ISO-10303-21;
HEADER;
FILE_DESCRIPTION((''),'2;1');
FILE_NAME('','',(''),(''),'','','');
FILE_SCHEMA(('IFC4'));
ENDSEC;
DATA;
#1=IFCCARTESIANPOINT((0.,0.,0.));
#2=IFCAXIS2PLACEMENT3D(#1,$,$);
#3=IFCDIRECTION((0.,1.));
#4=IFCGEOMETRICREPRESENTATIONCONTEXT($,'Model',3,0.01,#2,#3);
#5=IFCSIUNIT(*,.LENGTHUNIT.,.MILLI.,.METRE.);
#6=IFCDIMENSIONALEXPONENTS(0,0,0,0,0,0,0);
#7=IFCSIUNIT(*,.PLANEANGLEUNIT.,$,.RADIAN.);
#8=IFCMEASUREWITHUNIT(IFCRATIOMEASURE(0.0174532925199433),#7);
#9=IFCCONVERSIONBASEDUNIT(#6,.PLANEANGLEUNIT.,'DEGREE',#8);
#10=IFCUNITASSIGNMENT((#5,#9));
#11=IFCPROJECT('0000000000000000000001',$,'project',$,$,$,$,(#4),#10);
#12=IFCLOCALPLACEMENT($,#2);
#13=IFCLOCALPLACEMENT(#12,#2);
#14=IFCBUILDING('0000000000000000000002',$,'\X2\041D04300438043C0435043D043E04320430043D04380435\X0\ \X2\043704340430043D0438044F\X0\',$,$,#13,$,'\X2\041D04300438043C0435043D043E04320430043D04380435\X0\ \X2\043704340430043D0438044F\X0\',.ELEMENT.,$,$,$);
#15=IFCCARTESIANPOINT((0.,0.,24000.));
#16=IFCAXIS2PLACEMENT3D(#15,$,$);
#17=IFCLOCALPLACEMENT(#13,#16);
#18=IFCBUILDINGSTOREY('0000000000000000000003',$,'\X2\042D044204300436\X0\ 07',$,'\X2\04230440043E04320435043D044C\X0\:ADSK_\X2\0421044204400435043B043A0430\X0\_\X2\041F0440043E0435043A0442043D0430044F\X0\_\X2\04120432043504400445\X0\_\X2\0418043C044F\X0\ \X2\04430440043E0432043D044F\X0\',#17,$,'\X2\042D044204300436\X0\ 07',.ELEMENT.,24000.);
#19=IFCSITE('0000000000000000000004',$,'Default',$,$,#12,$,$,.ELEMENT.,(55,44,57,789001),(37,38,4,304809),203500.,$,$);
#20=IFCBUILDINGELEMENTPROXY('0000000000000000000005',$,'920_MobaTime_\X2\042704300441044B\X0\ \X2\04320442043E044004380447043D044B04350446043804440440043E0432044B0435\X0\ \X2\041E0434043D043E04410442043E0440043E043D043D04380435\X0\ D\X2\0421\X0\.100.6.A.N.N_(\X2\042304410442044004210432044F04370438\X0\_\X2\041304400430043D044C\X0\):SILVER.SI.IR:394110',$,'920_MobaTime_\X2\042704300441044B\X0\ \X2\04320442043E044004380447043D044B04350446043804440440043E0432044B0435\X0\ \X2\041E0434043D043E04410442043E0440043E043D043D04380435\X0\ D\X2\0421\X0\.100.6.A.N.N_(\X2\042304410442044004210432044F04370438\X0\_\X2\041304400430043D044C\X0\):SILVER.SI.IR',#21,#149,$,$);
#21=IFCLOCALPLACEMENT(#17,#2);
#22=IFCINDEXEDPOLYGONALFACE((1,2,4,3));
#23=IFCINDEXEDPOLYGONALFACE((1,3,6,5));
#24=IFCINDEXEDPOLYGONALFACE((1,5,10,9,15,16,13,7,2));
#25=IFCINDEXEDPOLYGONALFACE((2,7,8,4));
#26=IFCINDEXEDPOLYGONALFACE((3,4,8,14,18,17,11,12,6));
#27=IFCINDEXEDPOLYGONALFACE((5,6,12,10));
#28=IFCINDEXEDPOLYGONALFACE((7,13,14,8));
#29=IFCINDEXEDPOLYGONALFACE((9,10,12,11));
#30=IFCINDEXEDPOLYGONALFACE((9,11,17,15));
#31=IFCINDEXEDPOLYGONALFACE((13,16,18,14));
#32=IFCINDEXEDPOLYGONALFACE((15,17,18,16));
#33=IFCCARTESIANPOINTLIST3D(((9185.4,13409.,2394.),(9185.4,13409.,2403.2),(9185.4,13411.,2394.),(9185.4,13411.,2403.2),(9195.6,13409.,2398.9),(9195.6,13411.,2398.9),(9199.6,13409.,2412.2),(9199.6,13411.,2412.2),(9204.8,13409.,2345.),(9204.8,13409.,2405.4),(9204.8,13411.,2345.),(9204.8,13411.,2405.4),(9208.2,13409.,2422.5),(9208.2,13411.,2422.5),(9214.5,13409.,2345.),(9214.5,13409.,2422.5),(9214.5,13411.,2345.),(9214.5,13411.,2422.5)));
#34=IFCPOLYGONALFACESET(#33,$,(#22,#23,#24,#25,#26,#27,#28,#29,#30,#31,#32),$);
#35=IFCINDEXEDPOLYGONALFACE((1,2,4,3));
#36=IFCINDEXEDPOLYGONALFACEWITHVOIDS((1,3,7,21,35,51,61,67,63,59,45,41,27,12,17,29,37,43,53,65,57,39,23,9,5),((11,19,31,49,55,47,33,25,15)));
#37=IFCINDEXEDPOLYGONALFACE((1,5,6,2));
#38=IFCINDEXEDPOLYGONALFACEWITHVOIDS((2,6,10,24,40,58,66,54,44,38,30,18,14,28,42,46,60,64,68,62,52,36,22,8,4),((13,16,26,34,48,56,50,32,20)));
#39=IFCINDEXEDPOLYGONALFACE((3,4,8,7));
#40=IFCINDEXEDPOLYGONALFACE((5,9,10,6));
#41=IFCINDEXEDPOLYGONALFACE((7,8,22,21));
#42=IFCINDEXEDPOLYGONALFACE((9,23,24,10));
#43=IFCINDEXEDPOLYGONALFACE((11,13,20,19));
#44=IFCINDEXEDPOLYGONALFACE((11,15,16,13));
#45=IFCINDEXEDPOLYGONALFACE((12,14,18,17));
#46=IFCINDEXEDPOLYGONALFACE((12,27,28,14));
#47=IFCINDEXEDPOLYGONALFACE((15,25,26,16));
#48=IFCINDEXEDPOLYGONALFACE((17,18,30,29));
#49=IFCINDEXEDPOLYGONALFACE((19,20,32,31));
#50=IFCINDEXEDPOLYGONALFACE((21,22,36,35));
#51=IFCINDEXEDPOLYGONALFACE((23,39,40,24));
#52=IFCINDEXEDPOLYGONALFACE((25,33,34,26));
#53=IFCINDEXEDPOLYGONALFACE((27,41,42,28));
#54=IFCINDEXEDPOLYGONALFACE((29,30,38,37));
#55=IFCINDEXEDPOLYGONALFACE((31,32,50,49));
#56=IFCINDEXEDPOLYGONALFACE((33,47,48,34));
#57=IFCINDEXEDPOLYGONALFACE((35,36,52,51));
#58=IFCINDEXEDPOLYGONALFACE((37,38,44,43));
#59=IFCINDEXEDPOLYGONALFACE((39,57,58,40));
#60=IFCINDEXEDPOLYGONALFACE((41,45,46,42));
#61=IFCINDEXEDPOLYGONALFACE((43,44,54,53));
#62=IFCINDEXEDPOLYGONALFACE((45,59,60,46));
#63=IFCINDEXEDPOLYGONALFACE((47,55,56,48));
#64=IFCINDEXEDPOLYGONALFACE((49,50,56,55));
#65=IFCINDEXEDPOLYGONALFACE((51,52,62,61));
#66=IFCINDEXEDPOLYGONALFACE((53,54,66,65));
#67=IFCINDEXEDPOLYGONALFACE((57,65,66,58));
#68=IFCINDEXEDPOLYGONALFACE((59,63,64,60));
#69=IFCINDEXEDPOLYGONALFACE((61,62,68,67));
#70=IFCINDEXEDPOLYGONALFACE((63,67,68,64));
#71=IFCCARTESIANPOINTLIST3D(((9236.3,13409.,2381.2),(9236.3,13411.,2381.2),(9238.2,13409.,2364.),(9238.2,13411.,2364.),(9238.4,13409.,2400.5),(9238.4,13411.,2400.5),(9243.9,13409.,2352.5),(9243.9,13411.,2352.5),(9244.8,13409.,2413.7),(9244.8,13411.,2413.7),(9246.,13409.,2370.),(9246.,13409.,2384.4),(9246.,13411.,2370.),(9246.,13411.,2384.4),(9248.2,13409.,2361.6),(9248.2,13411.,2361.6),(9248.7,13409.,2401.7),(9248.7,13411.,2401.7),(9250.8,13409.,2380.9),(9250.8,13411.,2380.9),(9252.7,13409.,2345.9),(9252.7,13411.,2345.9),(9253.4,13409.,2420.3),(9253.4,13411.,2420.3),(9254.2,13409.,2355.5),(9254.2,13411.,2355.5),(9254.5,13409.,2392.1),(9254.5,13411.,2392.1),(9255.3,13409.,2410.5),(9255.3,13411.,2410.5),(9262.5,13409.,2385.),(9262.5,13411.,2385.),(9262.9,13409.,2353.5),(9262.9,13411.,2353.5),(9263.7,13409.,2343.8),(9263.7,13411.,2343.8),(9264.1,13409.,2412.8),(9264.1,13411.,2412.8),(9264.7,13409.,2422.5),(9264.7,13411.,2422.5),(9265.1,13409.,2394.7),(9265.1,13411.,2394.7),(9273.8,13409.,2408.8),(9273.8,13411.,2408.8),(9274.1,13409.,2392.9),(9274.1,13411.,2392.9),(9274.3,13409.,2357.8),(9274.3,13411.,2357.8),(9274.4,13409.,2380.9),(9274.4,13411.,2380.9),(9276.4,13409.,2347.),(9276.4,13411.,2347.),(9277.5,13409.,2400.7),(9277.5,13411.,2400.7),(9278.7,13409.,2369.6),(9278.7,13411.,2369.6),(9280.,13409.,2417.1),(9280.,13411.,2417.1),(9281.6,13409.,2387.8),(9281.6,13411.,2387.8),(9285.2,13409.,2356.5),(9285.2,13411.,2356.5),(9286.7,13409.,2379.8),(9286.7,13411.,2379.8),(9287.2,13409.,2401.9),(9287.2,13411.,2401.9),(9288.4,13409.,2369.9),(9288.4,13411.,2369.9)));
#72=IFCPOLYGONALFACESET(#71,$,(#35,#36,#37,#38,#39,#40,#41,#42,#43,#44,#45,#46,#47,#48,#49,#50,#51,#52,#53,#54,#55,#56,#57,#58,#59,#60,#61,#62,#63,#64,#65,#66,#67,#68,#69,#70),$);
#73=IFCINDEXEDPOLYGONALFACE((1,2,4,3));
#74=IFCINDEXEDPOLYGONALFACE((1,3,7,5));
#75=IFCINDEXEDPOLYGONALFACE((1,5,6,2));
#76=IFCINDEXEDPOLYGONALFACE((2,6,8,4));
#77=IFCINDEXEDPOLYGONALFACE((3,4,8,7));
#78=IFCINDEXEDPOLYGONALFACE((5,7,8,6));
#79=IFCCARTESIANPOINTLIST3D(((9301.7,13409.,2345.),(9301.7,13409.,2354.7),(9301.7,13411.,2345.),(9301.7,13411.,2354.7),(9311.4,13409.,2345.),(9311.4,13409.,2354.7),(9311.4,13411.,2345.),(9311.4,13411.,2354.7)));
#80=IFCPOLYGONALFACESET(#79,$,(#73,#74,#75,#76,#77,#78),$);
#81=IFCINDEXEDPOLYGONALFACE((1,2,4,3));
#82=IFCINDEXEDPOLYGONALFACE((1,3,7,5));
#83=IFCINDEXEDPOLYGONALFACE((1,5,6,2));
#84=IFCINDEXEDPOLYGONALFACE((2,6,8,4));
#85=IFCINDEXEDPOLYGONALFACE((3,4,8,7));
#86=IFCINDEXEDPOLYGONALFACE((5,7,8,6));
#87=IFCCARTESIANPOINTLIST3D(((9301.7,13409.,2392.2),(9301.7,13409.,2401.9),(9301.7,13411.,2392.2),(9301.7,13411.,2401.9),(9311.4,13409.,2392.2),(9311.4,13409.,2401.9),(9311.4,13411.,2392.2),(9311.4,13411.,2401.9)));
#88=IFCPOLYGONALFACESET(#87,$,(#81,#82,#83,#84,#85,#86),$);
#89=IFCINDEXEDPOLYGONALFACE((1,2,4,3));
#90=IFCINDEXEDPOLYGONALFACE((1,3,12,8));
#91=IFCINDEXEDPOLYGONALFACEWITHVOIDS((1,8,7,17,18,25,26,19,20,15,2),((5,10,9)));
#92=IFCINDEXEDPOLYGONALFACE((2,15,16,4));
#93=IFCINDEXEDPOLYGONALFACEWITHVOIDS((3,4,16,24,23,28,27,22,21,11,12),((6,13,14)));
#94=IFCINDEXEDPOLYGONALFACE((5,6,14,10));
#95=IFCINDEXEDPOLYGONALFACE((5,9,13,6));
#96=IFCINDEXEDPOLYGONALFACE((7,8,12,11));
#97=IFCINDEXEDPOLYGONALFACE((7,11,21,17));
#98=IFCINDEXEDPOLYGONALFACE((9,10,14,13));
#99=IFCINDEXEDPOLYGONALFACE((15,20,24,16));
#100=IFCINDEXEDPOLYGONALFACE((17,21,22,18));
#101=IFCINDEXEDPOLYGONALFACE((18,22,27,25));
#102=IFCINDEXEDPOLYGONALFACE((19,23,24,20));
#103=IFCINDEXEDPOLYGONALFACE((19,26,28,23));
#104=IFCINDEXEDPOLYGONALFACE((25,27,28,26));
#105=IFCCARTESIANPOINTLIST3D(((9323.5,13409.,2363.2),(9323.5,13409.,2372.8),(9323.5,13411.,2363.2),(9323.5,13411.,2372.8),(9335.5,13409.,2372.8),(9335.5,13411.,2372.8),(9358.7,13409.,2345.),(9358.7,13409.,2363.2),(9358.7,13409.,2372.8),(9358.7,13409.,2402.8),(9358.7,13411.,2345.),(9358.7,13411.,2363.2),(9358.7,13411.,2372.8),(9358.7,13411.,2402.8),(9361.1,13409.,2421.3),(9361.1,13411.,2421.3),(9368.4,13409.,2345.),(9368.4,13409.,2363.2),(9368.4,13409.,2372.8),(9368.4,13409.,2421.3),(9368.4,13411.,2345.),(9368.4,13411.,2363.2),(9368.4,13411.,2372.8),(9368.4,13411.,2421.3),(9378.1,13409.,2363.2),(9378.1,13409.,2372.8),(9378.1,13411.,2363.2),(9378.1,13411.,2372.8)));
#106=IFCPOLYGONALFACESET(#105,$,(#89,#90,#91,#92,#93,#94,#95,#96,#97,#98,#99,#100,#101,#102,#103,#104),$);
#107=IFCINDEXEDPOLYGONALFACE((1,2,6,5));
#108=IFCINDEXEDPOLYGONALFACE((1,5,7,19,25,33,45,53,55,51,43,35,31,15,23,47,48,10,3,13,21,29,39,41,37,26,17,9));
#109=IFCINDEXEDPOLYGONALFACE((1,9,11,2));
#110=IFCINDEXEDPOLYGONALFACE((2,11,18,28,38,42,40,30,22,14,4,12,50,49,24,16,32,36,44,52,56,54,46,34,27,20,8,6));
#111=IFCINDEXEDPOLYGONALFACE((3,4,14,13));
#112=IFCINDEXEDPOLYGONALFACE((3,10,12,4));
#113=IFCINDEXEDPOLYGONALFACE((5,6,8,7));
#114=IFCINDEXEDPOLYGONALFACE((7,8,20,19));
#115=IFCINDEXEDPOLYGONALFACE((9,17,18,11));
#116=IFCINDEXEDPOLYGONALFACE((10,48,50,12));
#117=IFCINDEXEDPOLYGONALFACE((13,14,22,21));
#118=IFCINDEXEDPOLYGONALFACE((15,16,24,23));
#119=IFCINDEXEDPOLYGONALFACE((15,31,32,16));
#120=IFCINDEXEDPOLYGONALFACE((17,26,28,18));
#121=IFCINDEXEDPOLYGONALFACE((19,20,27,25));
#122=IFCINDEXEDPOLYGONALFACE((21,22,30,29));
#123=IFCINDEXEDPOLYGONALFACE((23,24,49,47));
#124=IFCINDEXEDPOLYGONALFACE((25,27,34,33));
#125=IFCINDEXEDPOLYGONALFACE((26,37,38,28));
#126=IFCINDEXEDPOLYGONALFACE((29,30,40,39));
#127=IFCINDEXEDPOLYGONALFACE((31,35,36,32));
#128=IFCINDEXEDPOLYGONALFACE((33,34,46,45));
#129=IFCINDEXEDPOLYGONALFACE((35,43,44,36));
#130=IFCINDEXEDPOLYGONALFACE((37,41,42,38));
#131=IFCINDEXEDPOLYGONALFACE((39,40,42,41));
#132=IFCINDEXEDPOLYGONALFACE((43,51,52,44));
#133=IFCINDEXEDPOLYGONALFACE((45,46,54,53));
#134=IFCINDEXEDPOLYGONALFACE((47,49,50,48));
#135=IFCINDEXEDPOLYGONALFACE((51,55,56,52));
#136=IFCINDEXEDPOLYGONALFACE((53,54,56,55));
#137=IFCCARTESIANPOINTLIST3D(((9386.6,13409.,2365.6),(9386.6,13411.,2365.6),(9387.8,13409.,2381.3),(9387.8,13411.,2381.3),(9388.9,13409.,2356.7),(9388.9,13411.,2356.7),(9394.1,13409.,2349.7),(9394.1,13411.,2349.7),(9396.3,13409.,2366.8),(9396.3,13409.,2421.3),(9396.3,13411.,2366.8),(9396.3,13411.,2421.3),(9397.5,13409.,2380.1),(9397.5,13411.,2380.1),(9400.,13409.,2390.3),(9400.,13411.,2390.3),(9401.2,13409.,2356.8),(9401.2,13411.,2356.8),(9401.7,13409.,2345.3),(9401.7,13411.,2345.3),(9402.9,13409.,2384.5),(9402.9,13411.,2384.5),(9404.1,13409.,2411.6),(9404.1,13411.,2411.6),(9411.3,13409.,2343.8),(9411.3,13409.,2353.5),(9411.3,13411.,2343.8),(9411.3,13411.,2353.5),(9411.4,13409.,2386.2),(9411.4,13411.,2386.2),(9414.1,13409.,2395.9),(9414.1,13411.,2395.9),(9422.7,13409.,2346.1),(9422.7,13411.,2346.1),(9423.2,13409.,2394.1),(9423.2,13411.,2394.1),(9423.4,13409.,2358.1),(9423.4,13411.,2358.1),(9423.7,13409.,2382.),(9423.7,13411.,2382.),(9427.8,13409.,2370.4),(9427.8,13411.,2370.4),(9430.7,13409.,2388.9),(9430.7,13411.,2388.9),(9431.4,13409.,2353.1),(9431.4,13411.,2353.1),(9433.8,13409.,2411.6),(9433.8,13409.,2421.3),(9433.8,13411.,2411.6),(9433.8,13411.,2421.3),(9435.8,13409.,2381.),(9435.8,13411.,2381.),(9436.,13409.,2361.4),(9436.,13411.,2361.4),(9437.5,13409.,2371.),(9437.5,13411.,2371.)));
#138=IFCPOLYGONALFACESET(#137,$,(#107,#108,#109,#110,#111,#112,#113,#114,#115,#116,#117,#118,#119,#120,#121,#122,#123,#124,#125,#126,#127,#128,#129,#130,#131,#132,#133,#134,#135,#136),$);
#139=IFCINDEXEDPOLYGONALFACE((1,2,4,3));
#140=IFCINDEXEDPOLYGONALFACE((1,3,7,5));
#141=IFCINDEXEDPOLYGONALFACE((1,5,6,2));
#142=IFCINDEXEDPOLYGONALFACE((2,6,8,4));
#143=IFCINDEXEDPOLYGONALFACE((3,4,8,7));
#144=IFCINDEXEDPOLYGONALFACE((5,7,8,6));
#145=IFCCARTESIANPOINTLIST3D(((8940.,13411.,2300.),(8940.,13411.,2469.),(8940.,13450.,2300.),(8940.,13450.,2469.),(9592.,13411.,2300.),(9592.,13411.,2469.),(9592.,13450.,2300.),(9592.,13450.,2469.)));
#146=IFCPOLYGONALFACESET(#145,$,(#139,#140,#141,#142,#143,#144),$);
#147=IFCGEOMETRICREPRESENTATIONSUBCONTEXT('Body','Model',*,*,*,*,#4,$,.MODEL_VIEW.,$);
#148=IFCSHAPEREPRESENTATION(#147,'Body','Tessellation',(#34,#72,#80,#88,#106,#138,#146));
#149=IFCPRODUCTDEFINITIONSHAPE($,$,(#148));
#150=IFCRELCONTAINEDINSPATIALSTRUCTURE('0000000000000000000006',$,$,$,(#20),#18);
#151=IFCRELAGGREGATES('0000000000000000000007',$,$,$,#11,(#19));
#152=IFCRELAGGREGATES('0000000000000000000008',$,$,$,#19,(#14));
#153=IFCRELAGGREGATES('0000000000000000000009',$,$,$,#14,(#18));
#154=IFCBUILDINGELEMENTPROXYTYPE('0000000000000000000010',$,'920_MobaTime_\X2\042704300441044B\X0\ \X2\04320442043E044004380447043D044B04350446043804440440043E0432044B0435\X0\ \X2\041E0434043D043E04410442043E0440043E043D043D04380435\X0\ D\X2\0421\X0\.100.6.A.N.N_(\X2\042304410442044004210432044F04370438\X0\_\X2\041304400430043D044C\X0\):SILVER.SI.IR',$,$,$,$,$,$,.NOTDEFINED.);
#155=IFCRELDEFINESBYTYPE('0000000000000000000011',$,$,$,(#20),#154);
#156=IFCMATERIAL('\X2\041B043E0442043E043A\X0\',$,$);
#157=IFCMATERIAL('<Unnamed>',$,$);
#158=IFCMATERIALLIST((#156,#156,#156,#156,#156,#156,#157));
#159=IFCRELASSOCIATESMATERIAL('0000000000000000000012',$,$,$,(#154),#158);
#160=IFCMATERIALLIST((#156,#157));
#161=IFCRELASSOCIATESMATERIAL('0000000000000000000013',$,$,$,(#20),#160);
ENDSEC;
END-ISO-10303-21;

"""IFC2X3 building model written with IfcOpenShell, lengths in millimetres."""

from ifc_helpers import new_model, entity, si_unit, converted_unit, direction, frame, origin, origin_2d_with_axis, place, context, subcontext, project, spatial, polyline, rectangle, outline, extrude, source, transform, mapped, material, material_list, type_object, type_shapes, element, save


model = new_model("IFC2X3")

# Units and contexts
model_context = context("Model", 3, precision=0.01, world=origin(), true_north=direction((0.0, 1.0)))
body_context = subcontext(model_context, "Body", "Model", "MODEL_VIEW")
ifc_project = project(units=[si_unit("LENGTHUNIT", "METRE", prefix="MILLI"), converted_unit("PLANEANGLEUNIT", "DEGREE", entity("IfcRatioMeasure", 0.0174532925199433), si_unit("PLANEANGLEUNIT", "RADIAN"), dimensions=[0, 0, 0, 0, 0, 0, 0])], contexts=[model_context])

# Site, building, storey
site_placement = place(None, frame((0.0, 0.0, 0.0)))
site = spatial("IfcSite", under=ifc_project, at=site_placement, Name="Default", CompositionType="ELEMENT", RefLatitude=(55, 44, 57, 789001), RefLongitude=(37, 38, 4, 304809), RefElevation=203500.0)
building_placement = place(site_placement, origin())
building = spatial("IfcBuilding", under=site, at=building_placement, Name="Наименование здания", LongName="Наименование здания", CompositionType="ELEMENT")
storey_placement = place(building_placement, frame((0.0, 0.0, 24000.0)))
storey = spatial("IfcBuildingStorey", under=building, at=storey_placement, Name="Этаж 07", ObjectType="Уровень:ADSK_Стрелка_Проектная_Вверх_Имя уровня", LongName="Этаж 07", CompositionType="ELEMENT", Elevation=24000.0)

# Building element proxy
ifc_material_1 = material(Name="Лоток")
ifc_material_2 = material(Name="<Unnamed>")
ifc_material_list_1 = material_list([ifc_material_1, ifc_material_1, ifc_material_1, ifc_material_1, ifc_material_1, ifc_material_1, ifc_material_2])
building_element_proxy_type = type_object("IfcBuildingElementProxyType", Name="920_MobaTime_Часы вторичныецифровые Односторонние DС.100.6.A.N.N_(УстрСвязи_Грань):SILVER.SI.IR", PredefinedType="NOTDEFINED", material=ifc_material_list_1)
shared_shape = source(origin(), body_context, "Body", "SweptSolid", [
    extrude(outline(polyline([(-49.3, -13.1), (28.2, -13.1), (28.2, -6.8), (17.9, 1.8), (8.9, 16.0), (-0.3, 16.0), (4.6, 5.8), (11.1, -3.4), (-49.3, -3.4), (-49.3, -13.1)])), frame((-64.6, 9.8, 39.0), z_axis=(0.0, 0.0, 1.0), x_axis=(0.0, 1.0, 0.0)), (0.0, 0.0, 1.0), 2.0),
    extrude(outline(polyline([(2.2, -27.6), (19.0, -27.6), (30.5, -16.1), (33.3, -4.9), (31.0, 5.8), (21.8, 17.2), (5.2, 27.3), (-11.1, 33.0), (-24.0, 32.7), (-33.6, 27.6), (-40.3, 18.6), (-42.8, 5.7), (-38.0, -6.3), (-27.2, -15.0), (-17.5, -17.7), (-8.2, -16.4), (-0.3, -11.9), (5.1, -4.5), (7.3, 6.2), (4.0, 17.2), (18.5, 7.3), (23.6, -2.4), (22.0, -11.4), (14.2, -18.4), (5.3, -18.3), (2.2, -27.6)]), holes=[polyline([(-9.0, 23.3), (-1.3, 14.4), (-2.6, 2.0), (-11.4, -7.0), (-23.4, -6.1), (-32.2, 2.9), (-31.2, 15.1), (-25.6, 22.1), (-17.5, 24.9), (-9.0, 23.3)])]), frame((-2.7, 3.6, 39.0), z_axis=(0.0, 0.0, 1.0), x_axis=(-0.427649, 0.903945, 0.0)), (0.0, 0.0, 1.0), 2.0),
    extrude(rectangle(XDim=9.7, YDim=9.7, at=origin_2d_with_axis()), frame((40.6, -34.7, 39.0)), (0.0, 0.0, 1.0), 2.0),
    extrude(rectangle(XDim=9.7, YDim=9.7, at=origin_2d_with_axis()), frame((40.6, 12.6, 39.0)), (0.0, 0.0, 1.0), 2.0),
    extrude(outline(polyline([(-0.9, -28.1), (8.8, -28.1), (8.8, -9.9), (18.5, -9.9), (18.5, -0.2), (8.8, -0.2), (8.8, 48.3), (1.5, 48.3), (-36.0, -0.2), (-36.0, -9.9), (-0.9, -9.9), (-0.9, -28.1)]), holes=[polyline([(-0.9, -0.2), (-24.1, -0.2), (-0.9, 29.7), (-0.9, -0.2)])]), frame((93.6, -11.4, 39.0)), (0.0, 0.0, 1.0), 2.0),
    extrude(outline(polyline([(3.3, -28.3), (12.5, -28.3), (20.5, -25.0), (26.8, -18.8), (30.7, -10.0), (31.4, 1.6), (26.9, 11.8), (20.1, 18.4), (11.1, 22.3), (1.0, 23.3), (-7.9, 20.4), (-14.9, 14.5), (-18.9, 6.2), (-17.1, -9.0), (-36.7, 0.5), (-29.1, 29.3), (-38.5, 31.7), (-48.1, -4.6), (-11.6, -23.0), (-8.0, -14.0), (-10.8, -7.6), (-10.2, 1.1), (-3.0, 11.8), (9.2, 12.8), (20.0, 5.4), (21.3, -7.5), (15.5, -16.4), (4.6, -18.6), (3.3, -28.3)])), frame((147.1, -8.5, 39.0), z_axis=(0.0, 0.0, 1.0), x_axis=(0.256974, -0.966418, 0.0)), (0.0, 0.0, 1.0), 2.0),
    extrude(rectangle(XDim=652.0, YDim=169.0, at=origin_2d_with_axis()), frame((0.0, 0.0, 0.0), z_axis=(0.0, 0.0, 1.0), x_axis=(-1.0, 0.0, 0.0)), (0.0, 0.0, 1.0), 39.0),
])
type_shapes(building_element_proxy_type, [shared_shape])
ifc_material_list_2 = material_list([ifc_material_1, ifc_material_2])
proxy_1_placement = place(storey_placement, frame((9266.0, 13450.0, 2384.5), z_axis=(0.0, -1.0, 0.0), x_axis=(1.0, 0.0, 0.0)))
element("IfcBuildingElementProxy", 1, at=proxy_1_placement, inside=storey, type_object=building_element_proxy_type, material=ifc_material_list_2, Name="920_MobaTime_Часы вторичныецифровые Односторонние DС.100.6.A.N.N_(УстрСвязи_Грань):SILVER.SI.IR:394110", ObjectType="920_MobaTime_Часы вторичныецифровые Односторонние DС.100.6.A.N.N_(УстрСвязи_Грань):SILVER.SI.IR", context=body_context, shape_type="MappedRepresentation", body=[
    mapped(shared_shape, transform((0.0, 0.0, 0.0), scale=1.0)),
])

save(model, "model.ifc")
